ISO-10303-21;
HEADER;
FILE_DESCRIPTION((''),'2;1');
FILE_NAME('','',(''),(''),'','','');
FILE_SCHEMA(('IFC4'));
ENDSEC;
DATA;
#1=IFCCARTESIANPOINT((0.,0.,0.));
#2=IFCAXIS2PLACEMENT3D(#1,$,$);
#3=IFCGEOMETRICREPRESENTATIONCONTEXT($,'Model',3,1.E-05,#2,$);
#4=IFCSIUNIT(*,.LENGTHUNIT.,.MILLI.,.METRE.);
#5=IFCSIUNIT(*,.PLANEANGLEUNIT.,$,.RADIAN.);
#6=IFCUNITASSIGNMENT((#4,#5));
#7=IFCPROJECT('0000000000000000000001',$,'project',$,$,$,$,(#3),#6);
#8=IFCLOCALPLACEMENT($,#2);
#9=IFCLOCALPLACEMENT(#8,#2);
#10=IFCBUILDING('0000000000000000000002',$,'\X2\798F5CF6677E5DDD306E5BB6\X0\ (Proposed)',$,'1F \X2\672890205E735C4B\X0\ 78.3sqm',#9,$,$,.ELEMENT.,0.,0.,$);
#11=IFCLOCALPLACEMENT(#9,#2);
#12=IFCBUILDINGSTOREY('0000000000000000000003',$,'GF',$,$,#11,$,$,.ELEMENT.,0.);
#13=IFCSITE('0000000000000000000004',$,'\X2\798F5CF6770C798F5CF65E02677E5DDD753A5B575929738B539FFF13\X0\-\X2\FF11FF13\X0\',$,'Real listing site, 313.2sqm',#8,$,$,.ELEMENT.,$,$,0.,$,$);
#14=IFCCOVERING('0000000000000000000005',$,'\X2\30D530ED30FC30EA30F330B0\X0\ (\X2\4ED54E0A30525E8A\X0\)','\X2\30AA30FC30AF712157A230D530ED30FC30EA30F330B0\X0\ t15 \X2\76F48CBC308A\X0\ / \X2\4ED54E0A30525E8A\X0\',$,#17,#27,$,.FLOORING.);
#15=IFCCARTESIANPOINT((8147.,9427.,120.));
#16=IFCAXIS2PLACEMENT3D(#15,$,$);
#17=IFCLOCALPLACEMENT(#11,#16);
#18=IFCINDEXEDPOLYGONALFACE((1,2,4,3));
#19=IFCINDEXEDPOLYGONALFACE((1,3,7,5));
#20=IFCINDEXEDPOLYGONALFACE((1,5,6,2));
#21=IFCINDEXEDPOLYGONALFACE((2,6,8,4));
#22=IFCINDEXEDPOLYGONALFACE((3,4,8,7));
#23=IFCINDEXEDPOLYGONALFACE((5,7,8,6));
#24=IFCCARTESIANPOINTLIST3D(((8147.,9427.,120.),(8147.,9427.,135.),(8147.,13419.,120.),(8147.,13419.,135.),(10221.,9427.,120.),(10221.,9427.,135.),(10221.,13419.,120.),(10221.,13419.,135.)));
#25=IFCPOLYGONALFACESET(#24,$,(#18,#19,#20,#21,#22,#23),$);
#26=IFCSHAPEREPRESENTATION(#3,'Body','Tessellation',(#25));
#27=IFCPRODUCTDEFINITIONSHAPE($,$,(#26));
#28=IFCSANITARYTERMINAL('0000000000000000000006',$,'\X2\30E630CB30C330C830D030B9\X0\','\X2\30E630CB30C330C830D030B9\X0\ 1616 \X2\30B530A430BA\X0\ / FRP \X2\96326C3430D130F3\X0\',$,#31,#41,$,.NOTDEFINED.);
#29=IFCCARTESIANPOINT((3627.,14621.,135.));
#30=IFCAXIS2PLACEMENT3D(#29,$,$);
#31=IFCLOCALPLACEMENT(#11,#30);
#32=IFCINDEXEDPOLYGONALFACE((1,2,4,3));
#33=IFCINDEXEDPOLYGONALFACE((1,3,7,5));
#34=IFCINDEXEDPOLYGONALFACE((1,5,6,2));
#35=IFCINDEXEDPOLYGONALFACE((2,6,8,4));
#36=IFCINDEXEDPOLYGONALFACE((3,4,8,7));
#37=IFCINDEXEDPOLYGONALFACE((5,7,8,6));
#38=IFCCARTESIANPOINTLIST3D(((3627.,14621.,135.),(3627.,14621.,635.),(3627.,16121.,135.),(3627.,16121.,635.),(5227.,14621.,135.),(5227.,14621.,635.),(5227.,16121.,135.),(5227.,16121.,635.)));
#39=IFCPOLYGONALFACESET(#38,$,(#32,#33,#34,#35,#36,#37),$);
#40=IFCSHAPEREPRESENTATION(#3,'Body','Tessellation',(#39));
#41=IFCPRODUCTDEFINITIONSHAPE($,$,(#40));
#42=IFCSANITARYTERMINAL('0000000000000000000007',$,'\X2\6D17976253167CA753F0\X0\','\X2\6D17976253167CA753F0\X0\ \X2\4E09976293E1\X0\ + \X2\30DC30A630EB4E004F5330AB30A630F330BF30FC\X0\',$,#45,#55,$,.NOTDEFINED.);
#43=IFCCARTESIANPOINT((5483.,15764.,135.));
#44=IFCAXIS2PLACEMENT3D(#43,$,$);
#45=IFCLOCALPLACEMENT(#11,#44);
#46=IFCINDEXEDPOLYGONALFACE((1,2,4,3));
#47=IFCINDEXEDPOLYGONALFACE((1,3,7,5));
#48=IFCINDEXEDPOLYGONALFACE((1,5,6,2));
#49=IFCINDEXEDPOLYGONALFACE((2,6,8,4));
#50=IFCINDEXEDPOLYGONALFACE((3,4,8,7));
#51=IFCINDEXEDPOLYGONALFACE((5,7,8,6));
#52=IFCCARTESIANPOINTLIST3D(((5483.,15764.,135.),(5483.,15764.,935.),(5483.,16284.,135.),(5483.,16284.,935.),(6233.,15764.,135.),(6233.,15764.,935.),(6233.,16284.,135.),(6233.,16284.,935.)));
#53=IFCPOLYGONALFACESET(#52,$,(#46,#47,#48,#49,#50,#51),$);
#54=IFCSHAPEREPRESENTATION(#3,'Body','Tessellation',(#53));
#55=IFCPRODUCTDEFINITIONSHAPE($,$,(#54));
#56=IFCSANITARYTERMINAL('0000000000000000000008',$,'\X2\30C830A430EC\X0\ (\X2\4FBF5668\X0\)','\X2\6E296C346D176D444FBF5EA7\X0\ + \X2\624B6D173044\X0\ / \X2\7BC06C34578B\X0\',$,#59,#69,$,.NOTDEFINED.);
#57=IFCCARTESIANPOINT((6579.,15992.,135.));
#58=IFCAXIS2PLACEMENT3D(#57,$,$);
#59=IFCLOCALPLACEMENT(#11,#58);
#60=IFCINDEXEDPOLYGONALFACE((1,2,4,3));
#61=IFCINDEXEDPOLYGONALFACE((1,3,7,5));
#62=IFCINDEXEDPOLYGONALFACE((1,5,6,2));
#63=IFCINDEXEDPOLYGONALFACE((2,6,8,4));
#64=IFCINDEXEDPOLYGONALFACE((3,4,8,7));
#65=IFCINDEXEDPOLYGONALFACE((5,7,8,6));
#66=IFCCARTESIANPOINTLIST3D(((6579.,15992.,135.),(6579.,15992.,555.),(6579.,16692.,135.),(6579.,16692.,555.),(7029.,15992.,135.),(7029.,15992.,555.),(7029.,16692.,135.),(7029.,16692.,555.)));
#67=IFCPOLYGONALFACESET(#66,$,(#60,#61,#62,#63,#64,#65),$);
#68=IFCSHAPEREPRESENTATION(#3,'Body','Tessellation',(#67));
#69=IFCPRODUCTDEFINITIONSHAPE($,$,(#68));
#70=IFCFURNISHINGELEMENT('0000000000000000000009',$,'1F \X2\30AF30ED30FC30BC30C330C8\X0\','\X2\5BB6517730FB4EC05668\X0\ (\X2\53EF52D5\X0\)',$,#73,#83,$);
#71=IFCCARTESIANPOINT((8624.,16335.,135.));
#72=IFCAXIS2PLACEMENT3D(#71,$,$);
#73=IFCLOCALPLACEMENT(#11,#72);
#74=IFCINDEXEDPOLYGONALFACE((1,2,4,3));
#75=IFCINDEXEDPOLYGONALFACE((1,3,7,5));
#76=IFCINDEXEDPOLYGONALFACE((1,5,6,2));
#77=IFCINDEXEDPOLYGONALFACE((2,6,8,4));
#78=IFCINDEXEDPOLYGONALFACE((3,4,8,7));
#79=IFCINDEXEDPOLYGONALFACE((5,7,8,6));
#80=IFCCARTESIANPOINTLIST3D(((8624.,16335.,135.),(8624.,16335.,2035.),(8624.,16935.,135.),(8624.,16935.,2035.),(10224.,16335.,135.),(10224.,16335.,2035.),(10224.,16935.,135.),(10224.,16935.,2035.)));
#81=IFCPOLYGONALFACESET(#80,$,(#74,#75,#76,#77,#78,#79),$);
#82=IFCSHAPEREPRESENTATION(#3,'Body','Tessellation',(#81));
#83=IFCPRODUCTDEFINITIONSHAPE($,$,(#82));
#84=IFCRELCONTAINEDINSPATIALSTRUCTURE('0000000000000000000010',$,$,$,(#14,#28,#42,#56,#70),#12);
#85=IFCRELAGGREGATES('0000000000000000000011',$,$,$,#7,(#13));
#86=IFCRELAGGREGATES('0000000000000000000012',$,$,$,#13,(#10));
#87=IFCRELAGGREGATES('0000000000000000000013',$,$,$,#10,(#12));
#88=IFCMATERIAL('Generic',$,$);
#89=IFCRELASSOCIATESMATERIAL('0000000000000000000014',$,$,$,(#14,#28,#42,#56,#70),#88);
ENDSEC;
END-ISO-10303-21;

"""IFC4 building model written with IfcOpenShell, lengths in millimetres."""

from ifc_helpers import new_model, si_unit, frame, frame_2d, origin, place, context, project, spatial, rectangle, extrude, material, element, save


model = new_model("IFC4")

# Units and contexts
model_context = context("Model", 3, precision=1e-05, world=origin())
ifc_project = project(units=[si_unit("LENGTHUNIT", "METRE", prefix="MILLI"), si_unit("PLANEANGLEUNIT", "RADIAN")], contexts=[model_context])

# Site, building, storey
site_placement = place(None, origin())
site = spatial("IfcSite", under=ifc_project, at=site_placement, Name="福島県福島市松川町字天王原３-１３", ObjectType="Real listing site, 313.2sqm", CompositionType="ELEMENT", RefElevation=0.0)
building_placement = place(site_placement, origin())
building = spatial("IfcBuilding", under=site, at=building_placement, Name="福島松川の家 (Proposed)", ObjectType="1F 木造平屋 78.3sqm", CompositionType="ELEMENT", ElevationOfRefHeight=0.0, ElevationOfTerrain=0.0)
storey_placement = place(building_placement, origin())
storey = spatial("IfcBuildingStorey", under=building, at=storey_placement, Name="GF", CompositionType="ELEMENT", Elevation=0.0)

# Covering
ifc_material_1 = material(Name="Generic")
covering_1_placement = place(storey_placement, frame((8147.0, 9427.0, 120.0)))
element("IfcCovering", 1, at=covering_1_placement, inside=storey, material=ifc_material_1, Name="フローリング (仕上げ床)", Description="オーク無垢フローリング t15 直貼り / 仕上げ床", PredefinedType="FLOORING", context=model_context, shape_type="SweptSolid", body=[
    extrude(rectangle(XDim=2074.0, YDim=3992.0, at=frame_2d((1037.0, 1996.0))), frame((8147.0, 9427.0, 120.0)), (0.0, 0.0, 1.0), 15.0),
])

# Sanitary terminals
sanitary_terminal_1_placement = place(storey_placement, frame((3627.0, 14621.0, 135.0)))
element("IfcSanitaryTerminal", 2, at=sanitary_terminal_1_placement, inside=storey, material=ifc_material_1, Name="ユニットバス", Description="ユニットバス 1616 サイズ / FRP 防水パン", PredefinedType="NOTDEFINED", context=model_context, shape_type="SweptSolid", body=[
    extrude(rectangle(XDim=1600.0, YDim=1500.0, at=frame_2d((800.0, 750.0))), frame((3627.0, 14621.0, 135.0)), (0.0, 0.0, 1.0), 500.0),
])
sanitary_terminal_2_placement = place(storey_placement, frame((5483.0, 15764.0, 135.0)))
element("IfcSanitaryTerminal", 3, at=sanitary_terminal_2_placement, inside=storey, material=ifc_material_1, Name="洗面化粧台", Description="洗面化粧台 三面鏡 + ボウル一体カウンター", PredefinedType="NOTDEFINED", context=model_context, shape_type="SweptSolid", body=[
    extrude(rectangle(XDim=750.0, YDim=520.0, at=frame_2d((375.0, 260.0))), frame((5483.0, 15764.0, 135.0)), (0.0, 0.0, 1.0), 800.0),
])
sanitary_terminal_3_placement = place(storey_placement, frame((6579.0, 15992.0, 135.0)))
element("IfcSanitaryTerminal", 4, at=sanitary_terminal_3_placement, inside=storey, material=ifc_material_1, Name="トイレ (便器)", Description="温水洗浄便座 + 手洗い / 節水型", PredefinedType="NOTDEFINED", context=model_context, shape_type="SweptSolid", body=[
    extrude(rectangle(XDim=450.0, YDim=700.0, at=frame_2d((225.0, 350.0))), frame((6579.0, 15992.0, 135.0)), (0.0, 0.0, 1.0), 420.0),
])

# Furnishing element
furnishing_placement = place(storey_placement, frame((8624.0, 16335.0, 135.0)))
element("IfcFurnishingElement", 5, at=furnishing_placement, inside=storey, material=ifc_material_1, Name="1F クローゼット", Description="家具・什器 (可動)", context=model_context, shape_type="SweptSolid", body=[
    extrude(rectangle(XDim=1600.0, YDim=600.0, at=frame_2d((800.0, 300.0))), frame((8624.0, 16335.0, 135.0)), (0.0, 0.0, 1.0), 1900.0),
])

save(model, "model.ifc")
